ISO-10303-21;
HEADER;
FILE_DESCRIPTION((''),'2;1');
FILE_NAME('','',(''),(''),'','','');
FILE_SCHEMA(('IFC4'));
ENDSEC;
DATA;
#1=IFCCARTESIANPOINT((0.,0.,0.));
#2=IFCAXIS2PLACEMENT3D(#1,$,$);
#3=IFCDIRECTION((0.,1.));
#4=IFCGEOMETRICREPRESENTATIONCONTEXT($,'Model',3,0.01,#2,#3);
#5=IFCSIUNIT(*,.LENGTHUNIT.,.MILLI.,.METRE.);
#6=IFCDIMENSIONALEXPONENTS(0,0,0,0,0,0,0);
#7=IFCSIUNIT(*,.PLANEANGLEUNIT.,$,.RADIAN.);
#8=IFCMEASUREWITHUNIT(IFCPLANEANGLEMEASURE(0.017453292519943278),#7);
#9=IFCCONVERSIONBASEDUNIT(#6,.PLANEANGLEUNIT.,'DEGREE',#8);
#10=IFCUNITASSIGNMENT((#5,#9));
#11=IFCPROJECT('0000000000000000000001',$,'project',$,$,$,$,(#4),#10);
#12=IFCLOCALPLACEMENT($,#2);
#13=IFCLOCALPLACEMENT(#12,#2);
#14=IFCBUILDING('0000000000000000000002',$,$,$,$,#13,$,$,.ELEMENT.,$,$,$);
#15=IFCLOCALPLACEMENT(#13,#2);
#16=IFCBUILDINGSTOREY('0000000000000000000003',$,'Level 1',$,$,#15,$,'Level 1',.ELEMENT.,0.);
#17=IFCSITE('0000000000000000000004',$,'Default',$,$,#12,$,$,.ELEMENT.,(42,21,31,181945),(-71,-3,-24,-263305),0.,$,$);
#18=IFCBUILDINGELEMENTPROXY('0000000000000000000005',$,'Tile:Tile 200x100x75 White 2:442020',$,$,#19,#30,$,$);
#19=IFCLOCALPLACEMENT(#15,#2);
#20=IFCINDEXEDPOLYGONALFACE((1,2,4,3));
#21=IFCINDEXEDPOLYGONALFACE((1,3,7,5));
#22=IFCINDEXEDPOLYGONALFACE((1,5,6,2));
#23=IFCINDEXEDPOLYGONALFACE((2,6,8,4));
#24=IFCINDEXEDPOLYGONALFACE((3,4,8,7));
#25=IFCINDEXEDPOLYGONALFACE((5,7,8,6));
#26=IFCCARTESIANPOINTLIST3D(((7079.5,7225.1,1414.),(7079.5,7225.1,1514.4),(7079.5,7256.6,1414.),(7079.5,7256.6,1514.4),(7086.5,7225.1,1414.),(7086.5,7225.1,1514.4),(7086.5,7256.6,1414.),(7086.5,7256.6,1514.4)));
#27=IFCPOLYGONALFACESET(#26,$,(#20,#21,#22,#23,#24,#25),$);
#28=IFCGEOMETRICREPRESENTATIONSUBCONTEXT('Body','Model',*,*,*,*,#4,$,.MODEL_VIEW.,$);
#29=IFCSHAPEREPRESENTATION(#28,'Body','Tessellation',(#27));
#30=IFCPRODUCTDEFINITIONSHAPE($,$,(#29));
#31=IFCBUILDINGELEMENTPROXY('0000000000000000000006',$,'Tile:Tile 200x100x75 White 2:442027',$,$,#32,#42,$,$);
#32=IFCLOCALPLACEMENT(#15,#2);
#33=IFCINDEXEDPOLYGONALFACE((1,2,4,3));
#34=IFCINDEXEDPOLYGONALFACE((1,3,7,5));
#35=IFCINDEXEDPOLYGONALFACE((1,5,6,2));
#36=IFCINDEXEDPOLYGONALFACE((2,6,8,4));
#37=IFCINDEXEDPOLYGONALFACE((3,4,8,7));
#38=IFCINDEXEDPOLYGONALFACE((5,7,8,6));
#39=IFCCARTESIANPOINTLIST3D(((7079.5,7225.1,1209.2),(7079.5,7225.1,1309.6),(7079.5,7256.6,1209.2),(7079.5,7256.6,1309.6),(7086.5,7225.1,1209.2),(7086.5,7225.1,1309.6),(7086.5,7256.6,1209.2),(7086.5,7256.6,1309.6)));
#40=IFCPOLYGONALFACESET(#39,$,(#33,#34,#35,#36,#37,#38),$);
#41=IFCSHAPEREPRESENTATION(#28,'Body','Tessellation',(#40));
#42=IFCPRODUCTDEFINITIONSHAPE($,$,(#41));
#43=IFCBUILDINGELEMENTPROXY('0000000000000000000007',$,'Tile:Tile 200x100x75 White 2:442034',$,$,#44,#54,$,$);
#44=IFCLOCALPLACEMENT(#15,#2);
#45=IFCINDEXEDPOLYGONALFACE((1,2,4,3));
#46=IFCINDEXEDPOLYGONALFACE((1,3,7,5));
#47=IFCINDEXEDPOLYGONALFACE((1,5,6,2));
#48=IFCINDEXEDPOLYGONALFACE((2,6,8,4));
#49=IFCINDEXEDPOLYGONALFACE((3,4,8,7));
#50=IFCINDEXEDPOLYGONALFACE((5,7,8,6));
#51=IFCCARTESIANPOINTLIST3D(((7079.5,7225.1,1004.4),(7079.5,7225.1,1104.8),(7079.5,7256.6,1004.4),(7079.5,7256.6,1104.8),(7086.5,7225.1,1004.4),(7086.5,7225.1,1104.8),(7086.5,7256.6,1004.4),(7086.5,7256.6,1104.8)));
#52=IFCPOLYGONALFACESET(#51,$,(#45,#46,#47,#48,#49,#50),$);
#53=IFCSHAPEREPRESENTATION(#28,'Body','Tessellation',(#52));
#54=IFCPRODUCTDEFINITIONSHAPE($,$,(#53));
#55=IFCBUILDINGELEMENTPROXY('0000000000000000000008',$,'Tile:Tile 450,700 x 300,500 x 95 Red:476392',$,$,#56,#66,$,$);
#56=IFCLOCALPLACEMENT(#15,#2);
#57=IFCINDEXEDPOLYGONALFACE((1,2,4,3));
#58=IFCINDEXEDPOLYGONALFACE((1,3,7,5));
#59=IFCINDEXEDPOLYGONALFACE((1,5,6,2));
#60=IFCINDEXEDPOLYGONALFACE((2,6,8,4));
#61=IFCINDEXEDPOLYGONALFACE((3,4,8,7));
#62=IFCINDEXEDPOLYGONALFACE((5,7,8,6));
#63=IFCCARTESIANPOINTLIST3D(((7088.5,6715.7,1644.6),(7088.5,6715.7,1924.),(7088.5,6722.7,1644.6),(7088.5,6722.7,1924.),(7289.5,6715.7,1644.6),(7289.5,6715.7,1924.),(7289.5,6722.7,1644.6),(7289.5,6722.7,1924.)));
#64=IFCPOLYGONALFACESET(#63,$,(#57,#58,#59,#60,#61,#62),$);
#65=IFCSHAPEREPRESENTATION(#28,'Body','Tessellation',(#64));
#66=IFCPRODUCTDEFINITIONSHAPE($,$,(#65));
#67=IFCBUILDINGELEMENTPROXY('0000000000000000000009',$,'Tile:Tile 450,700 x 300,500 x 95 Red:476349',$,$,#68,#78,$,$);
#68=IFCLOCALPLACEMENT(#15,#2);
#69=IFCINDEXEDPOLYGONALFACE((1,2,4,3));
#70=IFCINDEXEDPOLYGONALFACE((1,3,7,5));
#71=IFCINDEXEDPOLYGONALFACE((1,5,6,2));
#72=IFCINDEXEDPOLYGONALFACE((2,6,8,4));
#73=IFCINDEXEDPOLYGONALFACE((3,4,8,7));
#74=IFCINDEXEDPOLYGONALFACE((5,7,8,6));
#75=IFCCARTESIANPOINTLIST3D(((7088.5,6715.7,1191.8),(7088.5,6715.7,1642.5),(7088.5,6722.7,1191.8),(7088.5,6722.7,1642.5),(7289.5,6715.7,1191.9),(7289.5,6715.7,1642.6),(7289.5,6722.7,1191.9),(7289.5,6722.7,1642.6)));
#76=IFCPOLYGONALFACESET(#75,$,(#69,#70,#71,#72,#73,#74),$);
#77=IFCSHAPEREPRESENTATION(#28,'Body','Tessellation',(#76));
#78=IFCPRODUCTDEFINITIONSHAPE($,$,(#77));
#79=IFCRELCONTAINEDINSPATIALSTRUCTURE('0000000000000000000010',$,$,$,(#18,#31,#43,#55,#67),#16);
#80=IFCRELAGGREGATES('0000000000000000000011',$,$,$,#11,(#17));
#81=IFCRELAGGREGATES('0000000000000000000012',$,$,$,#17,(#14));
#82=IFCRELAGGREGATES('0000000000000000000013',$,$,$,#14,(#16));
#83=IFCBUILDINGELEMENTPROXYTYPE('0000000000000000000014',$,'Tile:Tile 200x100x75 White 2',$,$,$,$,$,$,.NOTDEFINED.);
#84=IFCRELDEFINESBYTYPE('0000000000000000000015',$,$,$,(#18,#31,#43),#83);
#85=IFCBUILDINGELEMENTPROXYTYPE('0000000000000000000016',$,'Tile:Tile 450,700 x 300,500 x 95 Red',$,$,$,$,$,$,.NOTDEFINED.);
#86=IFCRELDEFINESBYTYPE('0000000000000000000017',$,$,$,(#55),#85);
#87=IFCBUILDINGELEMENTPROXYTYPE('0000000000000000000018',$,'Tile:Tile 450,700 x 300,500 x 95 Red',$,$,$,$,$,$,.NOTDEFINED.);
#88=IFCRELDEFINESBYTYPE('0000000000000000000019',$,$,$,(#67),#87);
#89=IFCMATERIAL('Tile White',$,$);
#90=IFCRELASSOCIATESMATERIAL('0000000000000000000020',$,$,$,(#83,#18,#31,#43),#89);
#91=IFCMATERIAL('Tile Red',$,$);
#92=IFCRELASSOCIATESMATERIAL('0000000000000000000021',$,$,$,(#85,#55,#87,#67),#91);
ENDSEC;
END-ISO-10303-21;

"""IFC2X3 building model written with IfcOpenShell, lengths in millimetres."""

from ifc_helpers import new_model, entity, si_unit, converted_unit, direction, frame, frame_2d, origin, origin_2d_with_axis, place, context, subcontext, project, spatial, rectangle, extrude, source, transform, mapped, material, type_object, type_shapes, element, save


model = new_model("IFC2X3")

# Units and contexts
model_context = context("Model", 3, precision=0.01, world=origin(), true_north=direction((0.0, 1.0)))
body_context = subcontext(model_context, "Body", "Model", "MODEL_VIEW")
ifc_project = project(units=[si_unit("LENGTHUNIT", "METRE", prefix="MILLI"), converted_unit("PLANEANGLEUNIT", "DEGREE", entity("IfcPlaneAngleMeasure", 0.017453292519943278), si_unit("PLANEANGLEUNIT", "RADIAN"), dimensions=[0, 0, 0, 0, 0, 0, 0])], contexts=[model_context])

# Site, building, storey
site_placement = place(None, origin())
site = spatial("IfcSite", under=ifc_project, at=site_placement, Name="Default", CompositionType="ELEMENT", RefLatitude=(42, 21, 31, 181945), RefLongitude=(-71, -3, -24, -263305), RefElevation=0.0)
building_placement = place(site_placement, origin())
building = spatial("IfcBuilding", under=site, at=building_placement, CompositionType="ELEMENT")
storey_placement = place(building_placement, origin())
storey = spatial("IfcBuildingStorey", under=building, at=storey_placement, Name="Level 1", LongName="Level 1", CompositionType="ELEMENT", Elevation=0.0)

# Building element proxies
ifc_material_1 = material(Name="Tile White")
building_element_proxy_type_1 = type_object("IfcBuildingElementProxyType", Name="Tile:Tile 200x100x75 White 2", PredefinedType="NOTDEFINED", material=ifc_material_1)
shared_shape_1 = source(origin(), body_context, "Body", "SweptSolid", [
    extrude(rectangle(XDim=100.4, YDim=31.5, at=origin_2d_with_axis()), frame((-50.2, 15.8, 0.0)), (0.0, 0.0, 1.0), 7.0),
])
type_shapes(building_element_proxy_type_1, [shared_shape_1])
for number, where, z_axis, x_axis, name in (
    (1, (7086.5, 7225.1, 1514.4), (-1.0, 0.0, 0.0), (0.0, 0.0, 1.0), "Tile:Tile 200x100x75 White 2:442020"),
    (2, (7086.5, 7225.1, 1309.6), (-1.0, 0.0, 0.0), (0.0, 0.0, 1.0), "Tile:Tile 200x100x75 White 2:442027"),
    (3, (7086.5, 7225.1, 1104.8), (-1.0, 0.0, 0.0), (0.0, 0.0, 1.0), "Tile:Tile 200x100x75 White 2:442034"),
):
    element("IfcBuildingElementProxy", number, at=place(storey_placement, frame(where, z_axis=z_axis, x_axis=x_axis)), inside=storey, type_object=building_element_proxy_type_1, material=ifc_material_1, Name=name, context=body_context, shape_type="MappedRepresentation", body=[
        mapped(shared_shape_1, transform((0.0, 0.0, 0.0), scale=1.0)),
    ])
ifc_material_2 = material(Name="Tile Red")
building_element_proxy_type_2 = type_object("IfcBuildingElementProxyType", Name="Tile:Tile 450,700 x 300,500 x 95 Red", PredefinedType="NOTDEFINED", material=ifc_material_2)
shared_shape_2 = source(origin(), body_context, "Body", "SweptSolid", [
    extrude(rectangle(XDim=201.0, YDim=279.5, at=frame_2d((0.0, 0.0), x_axis=(1.0, 0.0))), frame((-100.5, -139.7, 0.0), z_axis=(0.0, 0.0, 1.0), x_axis=(-1.0, 0.0, 0.0)), (0.0, 0.0, 1.0), 7.0),
])
type_shapes(building_element_proxy_type_2, [shared_shape_2])
proxy_1_placement = place(storey_placement, frame((7088.5, 6722.7, 1644.6), z_axis=(0.0, -1.0, 0.0), x_axis=(-1.0, 0.0, 0.0)))
element("IfcBuildingElementProxy", 4, at=proxy_1_placement, inside=storey, type_object=building_element_proxy_type_2, material=ifc_material_2, Name="Tile:Tile 450,700 x 300,500 x 95 Red:476392", context=body_context, shape_type="MappedRepresentation", body=[
    mapped(shared_shape_2, transform((0.0, 0.0, 0.0), scale=1.0)),
])
building_element_proxy_type_3 = type_object("IfcBuildingElementProxyType", Name="Tile:Tile 450,700 x 300,500 x 95 Red", PredefinedType="NOTDEFINED", material=ifc_material_2)
shared_shape_3 = source(origin(), body_context, "Body", "SweptSolid", [
    extrude(rectangle(XDim=201.0, YDim=450.7, at=frame_2d((0.0, 0.0), x_axis=(1.0, 0.0))), frame((-100.5, -225.4, 0.0), z_axis=(0.0, 0.0, 1.0), x_axis=(-1.0, 0.0, 0.0)), (0.0, 0.0, 1.0), 7.0),
])
type_shapes(building_element_proxy_type_3, [shared_shape_3])
proxy_2_placement = place(storey_placement, frame((7088.5, 6722.7, 1191.8), z_axis=(0.0, -1.0, 0.0), x_axis=(-1.0, 0.0, -0.000041)))
element("IfcBuildingElementProxy", 5, at=proxy_2_placement, inside=storey, type_object=building_element_proxy_type_3, material=ifc_material_2, Name="Tile:Tile 450,700 x 300,500 x 95 Red:476349", context=body_context, shape_type="MappedRepresentation", body=[
    mapped(shared_shape_3, transform((0.0, 0.0, 0.0), scale=1.0)),
])

save(model, "model.ifc")
